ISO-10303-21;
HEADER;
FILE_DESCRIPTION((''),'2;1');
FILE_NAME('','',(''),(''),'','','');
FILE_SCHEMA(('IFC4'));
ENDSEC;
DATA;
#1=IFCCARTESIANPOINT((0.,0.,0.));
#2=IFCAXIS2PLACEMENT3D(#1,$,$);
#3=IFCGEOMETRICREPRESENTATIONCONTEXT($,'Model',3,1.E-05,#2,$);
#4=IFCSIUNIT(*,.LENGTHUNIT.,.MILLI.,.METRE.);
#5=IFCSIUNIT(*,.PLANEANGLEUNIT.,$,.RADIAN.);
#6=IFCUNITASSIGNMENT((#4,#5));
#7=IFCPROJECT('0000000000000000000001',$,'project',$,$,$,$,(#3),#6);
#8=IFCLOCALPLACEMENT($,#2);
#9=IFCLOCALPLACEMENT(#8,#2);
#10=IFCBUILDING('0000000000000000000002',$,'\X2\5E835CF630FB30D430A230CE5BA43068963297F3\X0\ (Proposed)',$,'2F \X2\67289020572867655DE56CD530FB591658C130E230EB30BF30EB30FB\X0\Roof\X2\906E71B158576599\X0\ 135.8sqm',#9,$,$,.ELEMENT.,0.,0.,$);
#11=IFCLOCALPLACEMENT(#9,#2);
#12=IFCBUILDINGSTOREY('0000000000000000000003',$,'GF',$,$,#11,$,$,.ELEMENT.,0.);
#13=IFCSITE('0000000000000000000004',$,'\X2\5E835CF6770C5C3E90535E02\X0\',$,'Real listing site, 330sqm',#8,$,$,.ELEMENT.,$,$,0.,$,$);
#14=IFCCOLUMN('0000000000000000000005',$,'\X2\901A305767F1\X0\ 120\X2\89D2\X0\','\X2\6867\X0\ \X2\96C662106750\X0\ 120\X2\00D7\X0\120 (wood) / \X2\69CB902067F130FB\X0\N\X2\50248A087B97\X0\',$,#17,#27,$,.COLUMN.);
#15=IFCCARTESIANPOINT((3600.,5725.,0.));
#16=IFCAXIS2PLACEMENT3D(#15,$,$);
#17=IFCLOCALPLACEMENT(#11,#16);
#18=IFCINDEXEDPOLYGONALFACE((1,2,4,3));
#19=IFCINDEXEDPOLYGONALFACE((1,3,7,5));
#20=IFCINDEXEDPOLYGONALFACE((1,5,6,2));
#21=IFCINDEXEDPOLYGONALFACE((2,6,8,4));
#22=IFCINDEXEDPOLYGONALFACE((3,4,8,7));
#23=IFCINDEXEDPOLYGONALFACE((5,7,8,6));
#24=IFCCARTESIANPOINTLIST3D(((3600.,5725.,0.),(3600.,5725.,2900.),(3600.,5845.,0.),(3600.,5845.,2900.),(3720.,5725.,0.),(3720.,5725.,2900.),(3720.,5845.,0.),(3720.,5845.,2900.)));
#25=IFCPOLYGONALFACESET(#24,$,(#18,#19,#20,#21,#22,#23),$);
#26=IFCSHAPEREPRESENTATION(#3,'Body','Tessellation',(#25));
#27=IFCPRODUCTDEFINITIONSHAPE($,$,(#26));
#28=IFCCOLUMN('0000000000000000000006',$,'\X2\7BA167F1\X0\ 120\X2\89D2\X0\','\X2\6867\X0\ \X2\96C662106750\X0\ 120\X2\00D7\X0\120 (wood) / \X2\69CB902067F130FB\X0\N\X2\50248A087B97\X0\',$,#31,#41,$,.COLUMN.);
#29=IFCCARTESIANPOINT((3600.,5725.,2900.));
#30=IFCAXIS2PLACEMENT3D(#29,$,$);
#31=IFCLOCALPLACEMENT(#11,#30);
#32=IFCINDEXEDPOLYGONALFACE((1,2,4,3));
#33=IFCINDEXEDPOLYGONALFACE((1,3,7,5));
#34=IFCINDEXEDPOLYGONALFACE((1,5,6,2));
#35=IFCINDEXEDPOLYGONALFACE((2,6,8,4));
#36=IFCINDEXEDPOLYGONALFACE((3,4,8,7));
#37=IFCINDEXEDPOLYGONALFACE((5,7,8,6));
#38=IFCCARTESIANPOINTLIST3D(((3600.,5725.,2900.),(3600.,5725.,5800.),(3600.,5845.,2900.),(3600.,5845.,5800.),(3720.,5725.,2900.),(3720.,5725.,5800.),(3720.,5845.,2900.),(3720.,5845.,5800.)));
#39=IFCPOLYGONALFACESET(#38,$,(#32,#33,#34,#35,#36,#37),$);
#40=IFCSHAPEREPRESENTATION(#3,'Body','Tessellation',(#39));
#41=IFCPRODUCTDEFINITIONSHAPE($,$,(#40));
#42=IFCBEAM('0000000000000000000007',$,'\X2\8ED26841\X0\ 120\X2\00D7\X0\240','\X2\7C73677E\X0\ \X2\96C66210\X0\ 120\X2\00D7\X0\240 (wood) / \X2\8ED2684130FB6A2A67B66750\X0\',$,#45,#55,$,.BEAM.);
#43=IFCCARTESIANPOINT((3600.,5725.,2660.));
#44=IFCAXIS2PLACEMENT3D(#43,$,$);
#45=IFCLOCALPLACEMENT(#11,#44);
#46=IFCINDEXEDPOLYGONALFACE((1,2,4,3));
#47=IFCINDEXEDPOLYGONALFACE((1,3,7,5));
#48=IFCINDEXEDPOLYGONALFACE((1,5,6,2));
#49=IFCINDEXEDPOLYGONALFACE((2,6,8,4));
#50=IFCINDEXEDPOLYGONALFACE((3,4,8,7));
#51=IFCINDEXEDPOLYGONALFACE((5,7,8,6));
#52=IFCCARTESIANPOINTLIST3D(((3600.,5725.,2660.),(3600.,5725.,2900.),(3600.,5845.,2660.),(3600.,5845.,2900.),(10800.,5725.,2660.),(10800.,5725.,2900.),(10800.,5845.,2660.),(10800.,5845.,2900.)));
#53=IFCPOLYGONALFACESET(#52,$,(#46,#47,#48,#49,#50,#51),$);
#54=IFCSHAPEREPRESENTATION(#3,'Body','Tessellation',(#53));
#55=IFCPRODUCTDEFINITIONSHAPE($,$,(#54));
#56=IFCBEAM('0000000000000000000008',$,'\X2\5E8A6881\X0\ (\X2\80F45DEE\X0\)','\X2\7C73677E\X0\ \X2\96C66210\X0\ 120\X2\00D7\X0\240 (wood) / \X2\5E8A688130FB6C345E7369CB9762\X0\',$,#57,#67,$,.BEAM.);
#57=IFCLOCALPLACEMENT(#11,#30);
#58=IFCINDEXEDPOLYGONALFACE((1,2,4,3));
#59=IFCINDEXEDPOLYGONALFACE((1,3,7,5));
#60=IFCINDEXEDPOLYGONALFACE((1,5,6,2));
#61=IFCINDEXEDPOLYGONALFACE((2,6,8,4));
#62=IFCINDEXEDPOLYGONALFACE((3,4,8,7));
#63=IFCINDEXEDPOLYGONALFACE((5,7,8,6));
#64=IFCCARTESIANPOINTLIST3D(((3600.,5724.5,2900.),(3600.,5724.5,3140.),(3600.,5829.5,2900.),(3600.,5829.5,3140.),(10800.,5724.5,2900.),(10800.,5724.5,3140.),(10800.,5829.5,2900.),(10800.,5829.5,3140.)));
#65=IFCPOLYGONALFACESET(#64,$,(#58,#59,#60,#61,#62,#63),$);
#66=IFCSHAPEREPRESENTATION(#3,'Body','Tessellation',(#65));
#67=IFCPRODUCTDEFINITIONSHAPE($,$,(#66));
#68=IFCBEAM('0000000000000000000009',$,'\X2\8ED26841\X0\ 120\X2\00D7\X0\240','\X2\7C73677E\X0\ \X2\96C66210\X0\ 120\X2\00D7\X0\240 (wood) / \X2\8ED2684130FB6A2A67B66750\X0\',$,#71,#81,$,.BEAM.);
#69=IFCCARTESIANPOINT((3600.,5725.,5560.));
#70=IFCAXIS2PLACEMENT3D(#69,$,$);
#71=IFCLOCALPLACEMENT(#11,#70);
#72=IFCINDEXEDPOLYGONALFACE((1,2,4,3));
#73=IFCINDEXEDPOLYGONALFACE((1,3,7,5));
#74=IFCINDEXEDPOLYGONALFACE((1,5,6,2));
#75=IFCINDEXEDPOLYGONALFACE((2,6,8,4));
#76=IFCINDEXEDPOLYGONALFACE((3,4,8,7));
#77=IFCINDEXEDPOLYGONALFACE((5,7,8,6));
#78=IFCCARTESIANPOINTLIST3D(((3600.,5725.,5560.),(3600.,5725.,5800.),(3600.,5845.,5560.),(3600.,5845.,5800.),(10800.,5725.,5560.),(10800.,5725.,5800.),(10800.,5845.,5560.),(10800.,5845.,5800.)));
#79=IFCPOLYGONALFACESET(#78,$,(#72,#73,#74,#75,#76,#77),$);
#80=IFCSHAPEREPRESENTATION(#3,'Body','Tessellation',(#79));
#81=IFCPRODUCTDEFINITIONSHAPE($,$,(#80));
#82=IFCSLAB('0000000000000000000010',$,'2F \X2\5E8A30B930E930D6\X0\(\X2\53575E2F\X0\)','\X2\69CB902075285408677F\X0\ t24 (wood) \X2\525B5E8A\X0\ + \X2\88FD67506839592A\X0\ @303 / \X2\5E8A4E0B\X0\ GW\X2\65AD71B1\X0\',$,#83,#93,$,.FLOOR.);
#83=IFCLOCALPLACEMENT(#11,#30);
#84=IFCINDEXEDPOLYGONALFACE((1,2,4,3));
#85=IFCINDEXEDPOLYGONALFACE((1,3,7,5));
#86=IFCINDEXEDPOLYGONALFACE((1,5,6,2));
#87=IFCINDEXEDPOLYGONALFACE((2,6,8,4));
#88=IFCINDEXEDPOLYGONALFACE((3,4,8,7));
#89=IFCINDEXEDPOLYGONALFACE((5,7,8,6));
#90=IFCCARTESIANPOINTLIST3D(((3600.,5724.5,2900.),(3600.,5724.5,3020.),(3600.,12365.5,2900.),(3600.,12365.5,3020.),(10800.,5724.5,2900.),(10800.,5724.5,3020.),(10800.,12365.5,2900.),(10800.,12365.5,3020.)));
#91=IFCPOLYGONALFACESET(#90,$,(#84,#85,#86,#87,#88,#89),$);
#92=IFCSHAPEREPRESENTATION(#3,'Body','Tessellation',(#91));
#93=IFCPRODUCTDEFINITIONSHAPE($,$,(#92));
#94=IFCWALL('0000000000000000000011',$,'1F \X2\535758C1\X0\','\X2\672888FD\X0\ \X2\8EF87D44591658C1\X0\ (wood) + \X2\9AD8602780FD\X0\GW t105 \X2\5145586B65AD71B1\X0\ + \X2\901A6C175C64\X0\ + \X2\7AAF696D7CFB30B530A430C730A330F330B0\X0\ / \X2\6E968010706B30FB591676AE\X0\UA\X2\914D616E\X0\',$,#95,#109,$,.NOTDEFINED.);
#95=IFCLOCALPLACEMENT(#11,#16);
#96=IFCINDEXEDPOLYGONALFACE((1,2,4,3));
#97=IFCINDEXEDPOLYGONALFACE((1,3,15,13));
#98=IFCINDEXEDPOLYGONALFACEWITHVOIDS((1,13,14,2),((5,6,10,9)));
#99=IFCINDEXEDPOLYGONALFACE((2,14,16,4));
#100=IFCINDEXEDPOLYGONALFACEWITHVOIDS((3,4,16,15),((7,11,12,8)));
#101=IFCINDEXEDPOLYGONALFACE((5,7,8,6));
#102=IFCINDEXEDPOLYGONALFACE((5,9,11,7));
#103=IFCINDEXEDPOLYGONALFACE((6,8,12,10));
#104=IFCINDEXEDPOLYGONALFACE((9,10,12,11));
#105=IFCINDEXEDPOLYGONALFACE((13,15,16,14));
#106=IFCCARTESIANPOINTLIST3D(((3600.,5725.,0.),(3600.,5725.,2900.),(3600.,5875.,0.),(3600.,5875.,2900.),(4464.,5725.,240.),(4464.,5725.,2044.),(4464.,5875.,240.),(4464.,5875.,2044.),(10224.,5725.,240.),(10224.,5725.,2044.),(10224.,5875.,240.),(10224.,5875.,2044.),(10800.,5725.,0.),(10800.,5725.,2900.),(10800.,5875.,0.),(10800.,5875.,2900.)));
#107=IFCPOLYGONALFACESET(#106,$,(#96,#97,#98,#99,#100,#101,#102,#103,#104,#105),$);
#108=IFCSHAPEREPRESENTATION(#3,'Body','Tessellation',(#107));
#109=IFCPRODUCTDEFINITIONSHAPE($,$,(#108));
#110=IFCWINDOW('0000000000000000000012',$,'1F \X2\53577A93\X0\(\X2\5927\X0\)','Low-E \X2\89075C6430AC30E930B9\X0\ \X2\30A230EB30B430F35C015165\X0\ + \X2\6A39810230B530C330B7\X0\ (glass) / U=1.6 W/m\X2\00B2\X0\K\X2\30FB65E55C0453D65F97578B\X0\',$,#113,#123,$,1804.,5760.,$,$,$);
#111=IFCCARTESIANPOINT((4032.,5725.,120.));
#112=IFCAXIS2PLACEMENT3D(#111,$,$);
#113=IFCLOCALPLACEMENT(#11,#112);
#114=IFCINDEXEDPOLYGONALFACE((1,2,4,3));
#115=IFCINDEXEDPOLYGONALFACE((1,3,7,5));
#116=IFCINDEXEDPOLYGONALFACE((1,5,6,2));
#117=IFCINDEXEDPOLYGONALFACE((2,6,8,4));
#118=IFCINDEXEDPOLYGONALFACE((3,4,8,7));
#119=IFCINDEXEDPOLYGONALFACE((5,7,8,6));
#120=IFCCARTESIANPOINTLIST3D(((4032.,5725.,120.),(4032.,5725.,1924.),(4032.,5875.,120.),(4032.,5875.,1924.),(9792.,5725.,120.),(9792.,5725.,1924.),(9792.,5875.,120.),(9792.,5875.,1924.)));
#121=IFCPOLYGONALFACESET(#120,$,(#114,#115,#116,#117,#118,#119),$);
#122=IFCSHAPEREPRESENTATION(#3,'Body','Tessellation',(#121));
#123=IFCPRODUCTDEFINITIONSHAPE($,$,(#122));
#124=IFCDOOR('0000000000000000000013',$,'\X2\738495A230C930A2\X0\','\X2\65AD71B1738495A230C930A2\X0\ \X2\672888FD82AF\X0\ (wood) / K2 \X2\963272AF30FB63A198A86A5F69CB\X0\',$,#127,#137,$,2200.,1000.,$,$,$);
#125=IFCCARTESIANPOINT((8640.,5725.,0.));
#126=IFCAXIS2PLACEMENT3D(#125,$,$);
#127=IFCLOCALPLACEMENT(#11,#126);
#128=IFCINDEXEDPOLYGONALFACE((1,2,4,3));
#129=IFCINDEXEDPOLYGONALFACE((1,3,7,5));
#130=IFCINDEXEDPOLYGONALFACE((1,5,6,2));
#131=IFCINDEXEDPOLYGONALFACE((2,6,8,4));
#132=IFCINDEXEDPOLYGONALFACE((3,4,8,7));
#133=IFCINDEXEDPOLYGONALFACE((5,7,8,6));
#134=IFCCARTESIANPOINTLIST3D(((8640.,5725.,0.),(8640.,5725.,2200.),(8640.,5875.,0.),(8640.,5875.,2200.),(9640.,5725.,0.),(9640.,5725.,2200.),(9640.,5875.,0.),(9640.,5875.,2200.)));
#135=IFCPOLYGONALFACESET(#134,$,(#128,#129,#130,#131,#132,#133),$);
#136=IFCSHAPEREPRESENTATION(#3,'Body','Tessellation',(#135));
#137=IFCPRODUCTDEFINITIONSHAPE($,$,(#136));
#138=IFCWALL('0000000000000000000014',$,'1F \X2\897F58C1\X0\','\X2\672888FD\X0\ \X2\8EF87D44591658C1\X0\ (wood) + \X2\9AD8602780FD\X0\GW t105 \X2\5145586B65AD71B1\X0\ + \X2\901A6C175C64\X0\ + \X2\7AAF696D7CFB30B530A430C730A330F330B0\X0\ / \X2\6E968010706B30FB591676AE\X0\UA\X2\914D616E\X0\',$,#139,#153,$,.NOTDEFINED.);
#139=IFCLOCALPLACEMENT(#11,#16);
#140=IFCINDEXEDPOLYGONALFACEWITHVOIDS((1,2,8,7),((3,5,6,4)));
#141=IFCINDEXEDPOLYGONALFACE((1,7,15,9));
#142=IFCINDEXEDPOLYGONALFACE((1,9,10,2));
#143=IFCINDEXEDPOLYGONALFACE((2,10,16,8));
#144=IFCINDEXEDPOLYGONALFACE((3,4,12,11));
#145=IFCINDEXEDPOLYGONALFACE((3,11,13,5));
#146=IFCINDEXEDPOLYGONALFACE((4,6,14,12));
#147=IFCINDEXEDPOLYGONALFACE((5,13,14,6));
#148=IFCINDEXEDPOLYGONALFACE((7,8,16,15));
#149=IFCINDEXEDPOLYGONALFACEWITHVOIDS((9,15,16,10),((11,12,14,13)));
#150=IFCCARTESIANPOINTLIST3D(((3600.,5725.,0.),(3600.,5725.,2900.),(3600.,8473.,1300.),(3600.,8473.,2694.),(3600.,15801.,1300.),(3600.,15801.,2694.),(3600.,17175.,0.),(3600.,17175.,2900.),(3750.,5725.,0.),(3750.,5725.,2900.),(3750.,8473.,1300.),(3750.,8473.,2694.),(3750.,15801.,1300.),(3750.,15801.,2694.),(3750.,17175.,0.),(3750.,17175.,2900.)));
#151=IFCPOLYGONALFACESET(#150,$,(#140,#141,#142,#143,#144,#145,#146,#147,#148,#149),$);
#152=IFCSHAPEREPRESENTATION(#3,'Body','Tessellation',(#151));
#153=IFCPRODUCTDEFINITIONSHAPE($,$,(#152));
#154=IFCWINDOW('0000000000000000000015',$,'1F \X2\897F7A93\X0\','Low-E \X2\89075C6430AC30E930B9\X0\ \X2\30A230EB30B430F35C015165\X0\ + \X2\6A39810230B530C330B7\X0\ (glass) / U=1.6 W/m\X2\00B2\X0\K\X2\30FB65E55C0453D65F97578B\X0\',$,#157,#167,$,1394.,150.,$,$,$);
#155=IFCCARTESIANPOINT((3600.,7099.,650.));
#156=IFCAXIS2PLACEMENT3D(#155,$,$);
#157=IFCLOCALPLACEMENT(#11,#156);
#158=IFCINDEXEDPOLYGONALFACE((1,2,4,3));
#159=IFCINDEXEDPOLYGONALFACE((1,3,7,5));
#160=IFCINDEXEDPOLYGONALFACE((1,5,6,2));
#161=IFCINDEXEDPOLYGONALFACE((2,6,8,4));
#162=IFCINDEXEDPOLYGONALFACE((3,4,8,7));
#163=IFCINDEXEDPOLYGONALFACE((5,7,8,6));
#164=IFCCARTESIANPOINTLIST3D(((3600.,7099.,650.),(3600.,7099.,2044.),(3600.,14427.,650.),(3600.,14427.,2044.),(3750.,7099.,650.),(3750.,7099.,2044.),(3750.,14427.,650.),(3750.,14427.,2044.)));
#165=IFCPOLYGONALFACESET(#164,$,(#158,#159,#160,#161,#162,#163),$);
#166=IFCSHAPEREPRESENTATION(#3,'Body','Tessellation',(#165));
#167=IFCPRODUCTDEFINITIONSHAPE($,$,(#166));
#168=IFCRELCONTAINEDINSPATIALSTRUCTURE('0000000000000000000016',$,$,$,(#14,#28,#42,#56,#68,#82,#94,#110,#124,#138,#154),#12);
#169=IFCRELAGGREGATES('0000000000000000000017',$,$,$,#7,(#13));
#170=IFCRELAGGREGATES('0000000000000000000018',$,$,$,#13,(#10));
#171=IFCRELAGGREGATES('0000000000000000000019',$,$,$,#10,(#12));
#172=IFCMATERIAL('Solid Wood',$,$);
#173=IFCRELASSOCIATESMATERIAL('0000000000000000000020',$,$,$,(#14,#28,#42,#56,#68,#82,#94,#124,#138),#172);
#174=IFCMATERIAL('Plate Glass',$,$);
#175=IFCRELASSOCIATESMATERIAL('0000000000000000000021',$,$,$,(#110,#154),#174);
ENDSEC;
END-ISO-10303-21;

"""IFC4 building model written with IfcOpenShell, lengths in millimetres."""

from ifc_helpers import new_model, si_unit, frame, frame_2d, origin, place, context, project, spatial, rectangle, extrude, material, element, fill, save


model = new_model("IFC4")

# Units and contexts
model_context = context("Model", 3, precision=1e-05, world=origin())
ifc_project = project(units=[si_unit("LENGTHUNIT", "METRE", prefix="MILLI"), si_unit("PLANEANGLEUNIT", "RADIAN")], contexts=[model_context])

# Site, building, storey
site_placement = place(None, origin())
site = spatial("IfcSite", under=ifc_project, at=site_placement, Name="広島県尾道市", ObjectType="Real listing site, 330sqm", CompositionType="ELEMENT", RefElevation=0.0)
building_placement = place(site_placement, origin())
building = spatial("IfcBuilding", under=site, at=building_placement, Name="広島・ピアノ室と防音 (Proposed)", ObjectType="2F 木造在来工法・外壁モルタル・Roof遮熱塗料 135.8sqm", CompositionType="ELEMENT", ElevationOfRefHeight=0.0, ElevationOfTerrain=0.0)
storey_placement = place(building_placement, origin())
storey = spatial("IfcBuildingStorey", under=building, at=storey_placement, Name="GF", CompositionType="ELEMENT", Elevation=0.0)

# Columns
ifc_material_1 = material(Name="Solid Wood")
column_1_placement = place(storey_placement, frame((3600.0, 5725.0, 0.0)))
element("IfcColumn", 1, at=column_1_placement, inside=storey, material=ifc_material_1, Name="通し柱 120角", Description="桧 集成材 120×120 (wood) / 構造柱・N値計算", PredefinedType="COLUMN", context=model_context, shape_type="SweptSolid", body=[
    extrude(rectangle(XDim=120.0, YDim=120.0, at=frame_2d((60.0, 60.0))), frame((3600.0, 5725.0, 0.0)), (0.0, 0.0, 1.0), 2900.0),
])
column_2_placement = place(storey_placement, frame((3600.0, 5725.0, 2900.0)))
element("IfcColumn", 2, at=column_2_placement, inside=storey, material=ifc_material_1, Name="管柱 120角", Description="桧 集成材 120×120 (wood) / 構造柱・N値計算", PredefinedType="COLUMN", context=model_context, shape_type="SweptSolid", body=[
    extrude(rectangle(XDim=120.0, YDim=120.0, at=frame_2d((60.0, 60.0))), frame((3600.0, 5725.0, 2900.0)), (0.0, 0.0, 1.0), 2900.0),
])

# Beams
beam_1_placement = place(storey_placement, frame((3600.0, 5725.0, 2660.0)))
element("IfcBeam", 3, at=beam_1_placement, inside=storey, material=ifc_material_1, Name="軒桁 120×240", Description="米松 集成 120×240 (wood) / 軒桁・横架材", PredefinedType="BEAM", context=model_context, shape_type="SweptSolid", body=[
    extrude(rectangle(XDim=7200.0, YDim=120.0, at=frame_2d((3600.0, 60.0))), frame((3600.0, 5725.0, 2660.0)), (0.0, 0.0, 1.0), 240.0),
])
beam_2_placement = place(storey_placement, frame((3600.0, 5725.0, 2900.0)))
element("IfcBeam", 4, at=beam_2_placement, inside=storey, material=ifc_material_1, Name="床梁 (胴差)", Description="米松 集成 120×240 (wood) / 床梁・水平構面", PredefinedType="BEAM", context=model_context, shape_type="SweptSolid", body=[
    extrude(rectangle(XDim=7200.0, YDim=105.0, at=frame_2d((3600.0, 52.0))), frame((3600.0, 5725.0, 2900.0)), (0.0, 0.0, 1.0), 240.0),
])
beam_3_placement = place(storey_placement, frame((3600.0, 5725.0, 5560.0)))
element("IfcBeam", 5, at=beam_3_placement, inside=storey, material=ifc_material_1, Name="軒桁 120×240", Description="米松 集成 120×240 (wood) / 軒桁・横架材", PredefinedType="BEAM", context=model_context, shape_type="SweptSolid", body=[
    extrude(rectangle(XDim=7200.0, YDim=120.0, at=frame_2d((3600.0, 60.0))), frame((3600.0, 5725.0, 5560.0)), (0.0, 0.0, 1.0), 240.0),
])

# Slab
slab_1_placement = place(storey_placement, frame((3600.0, 5725.0, 2900.0)))
element("IfcSlab", 6, at=slab_1_placement, inside=storey, material=ifc_material_1, Name="2F 床スラブ(南帯)", Description="構造用合板 t24 (wood) 剛床 + 製材根太 @303 / 床下 GW断熱", PredefinedType="FLOOR", context=model_context, shape_type="SweptSolid", body=[
    extrude(rectangle(XDim=7200.0, YDim=6641.0, at=frame_2d((3600.0, 3320.0))), frame((3600.0, 5725.0, 2900.0)), (0.0, 0.0, 1.0), 120.0),
])

# Wall, openings, window, door
wall_1_placement = place(storey_placement, frame((3600.0, 5725.0, 0.0)))
wall_1 = element("IfcWall", 7, at=wall_1_placement, inside=storey, material=ifc_material_1, Name="1F 南壁", Description="木製 軸組外壁 (wood) + 高性能GW t105 充填断熱 + 通気層 + 窯業系サイディング / 準耐火・外皮UA配慮", PredefinedType="NOTDEFINED", context=model_context, shape_type="SweptSolid", body=[
    extrude(rectangle(XDim=7200.0, YDim=150.0, at=frame_2d((3600.0, 75.0))), frame((3600.0, 5725.0, 0.0)), (0.0, 0.0, 1.0), 2900.0),
])
opening_1_placement = place(storey_placement, frame((4032.0, 5725.0, 120.0)))
opening_1 = element("IfcOpeningElement", 8, at=opening_1_placement, cuts=wall_1, PredefinedType="NOTDEFINED", context=model_context, shape_type="SweptSolid", body=[
    extrude(rectangle(XDim=5760.0, YDim=150.0, at=frame_2d((2880.0, 75.0))), frame((4032.0, 5725.0, 120.0)), (0.0, 0.0, 1.0), 1804.0),
])
opening_2_placement = place(storey_placement, frame((8640.0, 5725.0, 0.0)))
opening_2 = element("IfcOpeningElement", 9, at=opening_2_placement, cuts=wall_1, PredefinedType="NOTDEFINED", context=model_context, shape_type="SweptSolid", body=[
    extrude(rectangle(XDim=1000.0, YDim=150.0, at=frame_2d((500.0, 75.0))), frame((8640.0, 5725.0, 0.0)), (0.0, 0.0, 1.0), 2200.0),
])
ifc_material_2 = material(Name="Plate Glass")
window_1_placement = place(storey_placement, frame((4032.0, 5725.0, 120.0)))
window_1 = element("IfcWindow", 10, at=window_1_placement, inside=storey, material=ifc_material_2, Name="1F 南窓(大)", Description="Low-E 複層ガラス アルゴン封入 + 樹脂サッシ (glass) / U=1.6 W/m²K・日射取得型", OverallHeight=1804.0, OverallWidth=5760.0, context=model_context, shape_type="SweptSolid", body=[
    extrude(rectangle(XDim=5760.0, YDim=150.0, at=frame_2d((2880.0, 75.0))), frame((4032.0, 5725.0, 120.0)), (0.0, 0.0, 1.0), 1804.0),
])
fill(opening_1, window_1)
door_placement = place(storey_placement, frame((8640.0, 5725.0, 0.0)))
door = element("IfcDoor", 11, at=door_placement, inside=storey, material=ifc_material_1, Name="玄関ドア", Description="断熱玄関ドア 木製芯 (wood) / K2 防犯・採風機構", OverallHeight=2200.0, OverallWidth=1000.0, context=model_context, shape_type="SweptSolid", body=[
    extrude(rectangle(XDim=1000.0, YDim=150.0, at=frame_2d((500.0, 75.0))), frame((8640.0, 5725.0, 0.0)), (0.0, 0.0, 1.0), 2200.0),
])
fill(opening_2, door)

# Wall, opening, window
wall_2_placement = place(storey_placement, frame((3600.0, 5725.0, 0.0)))
wall_2 = element("IfcWall", 12, at=wall_2_placement, inside=storey, material=ifc_material_1, Name="1F 西壁", Description="木製 軸組外壁 (wood) + 高性能GW t105 充填断熱 + 通気層 + 窯業系サイディング / 準耐火・外皮UA配慮", PredefinedType="NOTDEFINED", context=model_context, shape_type="SweptSolid", body=[
    extrude(rectangle(XDim=150.0, YDim=11450.0, at=frame_2d((75.0, 5725.0))), frame((3600.0, 5725.0, 0.0)), (0.0, 0.0, 1.0), 2900.0),
])
opening_3_placement = place(storey_placement, frame((3600.0, 7099.0, 650.0)))
opening_3 = element("IfcOpeningElement", 13, at=opening_3_placement, cuts=wall_2, PredefinedType="NOTDEFINED", context=model_context, shape_type="SweptSolid", body=[
    extrude(rectangle(XDim=150.0, YDim=7328.0, at=frame_2d((75.0, 3664.0))), frame((3600.0, 7099.0, 650.0)), (0.0, 0.0, 1.0), 1394.0),
])
window_2_placement = place(storey_placement, frame((3600.0, 7099.0, 650.0)))
window_2 = element("IfcWindow", 14, at=window_2_placement, inside=storey, material=ifc_material_2, Name="1F 西窓", Description="Low-E 複層ガラス アルゴン封入 + 樹脂サッシ (glass) / U=1.6 W/m²K・日射取得型", OverallHeight=1394.0, OverallWidth=150.0, context=model_context, shape_type="SweptSolid", body=[
    extrude(rectangle(XDim=150.0, YDim=7328.0, at=frame_2d((75.0, 3664.0))), frame((3600.0, 7099.0, 650.0)), (0.0, 0.0, 1.0), 1394.0),
])
fill(opening_3, window_2)

save(model, "model.ifc")
